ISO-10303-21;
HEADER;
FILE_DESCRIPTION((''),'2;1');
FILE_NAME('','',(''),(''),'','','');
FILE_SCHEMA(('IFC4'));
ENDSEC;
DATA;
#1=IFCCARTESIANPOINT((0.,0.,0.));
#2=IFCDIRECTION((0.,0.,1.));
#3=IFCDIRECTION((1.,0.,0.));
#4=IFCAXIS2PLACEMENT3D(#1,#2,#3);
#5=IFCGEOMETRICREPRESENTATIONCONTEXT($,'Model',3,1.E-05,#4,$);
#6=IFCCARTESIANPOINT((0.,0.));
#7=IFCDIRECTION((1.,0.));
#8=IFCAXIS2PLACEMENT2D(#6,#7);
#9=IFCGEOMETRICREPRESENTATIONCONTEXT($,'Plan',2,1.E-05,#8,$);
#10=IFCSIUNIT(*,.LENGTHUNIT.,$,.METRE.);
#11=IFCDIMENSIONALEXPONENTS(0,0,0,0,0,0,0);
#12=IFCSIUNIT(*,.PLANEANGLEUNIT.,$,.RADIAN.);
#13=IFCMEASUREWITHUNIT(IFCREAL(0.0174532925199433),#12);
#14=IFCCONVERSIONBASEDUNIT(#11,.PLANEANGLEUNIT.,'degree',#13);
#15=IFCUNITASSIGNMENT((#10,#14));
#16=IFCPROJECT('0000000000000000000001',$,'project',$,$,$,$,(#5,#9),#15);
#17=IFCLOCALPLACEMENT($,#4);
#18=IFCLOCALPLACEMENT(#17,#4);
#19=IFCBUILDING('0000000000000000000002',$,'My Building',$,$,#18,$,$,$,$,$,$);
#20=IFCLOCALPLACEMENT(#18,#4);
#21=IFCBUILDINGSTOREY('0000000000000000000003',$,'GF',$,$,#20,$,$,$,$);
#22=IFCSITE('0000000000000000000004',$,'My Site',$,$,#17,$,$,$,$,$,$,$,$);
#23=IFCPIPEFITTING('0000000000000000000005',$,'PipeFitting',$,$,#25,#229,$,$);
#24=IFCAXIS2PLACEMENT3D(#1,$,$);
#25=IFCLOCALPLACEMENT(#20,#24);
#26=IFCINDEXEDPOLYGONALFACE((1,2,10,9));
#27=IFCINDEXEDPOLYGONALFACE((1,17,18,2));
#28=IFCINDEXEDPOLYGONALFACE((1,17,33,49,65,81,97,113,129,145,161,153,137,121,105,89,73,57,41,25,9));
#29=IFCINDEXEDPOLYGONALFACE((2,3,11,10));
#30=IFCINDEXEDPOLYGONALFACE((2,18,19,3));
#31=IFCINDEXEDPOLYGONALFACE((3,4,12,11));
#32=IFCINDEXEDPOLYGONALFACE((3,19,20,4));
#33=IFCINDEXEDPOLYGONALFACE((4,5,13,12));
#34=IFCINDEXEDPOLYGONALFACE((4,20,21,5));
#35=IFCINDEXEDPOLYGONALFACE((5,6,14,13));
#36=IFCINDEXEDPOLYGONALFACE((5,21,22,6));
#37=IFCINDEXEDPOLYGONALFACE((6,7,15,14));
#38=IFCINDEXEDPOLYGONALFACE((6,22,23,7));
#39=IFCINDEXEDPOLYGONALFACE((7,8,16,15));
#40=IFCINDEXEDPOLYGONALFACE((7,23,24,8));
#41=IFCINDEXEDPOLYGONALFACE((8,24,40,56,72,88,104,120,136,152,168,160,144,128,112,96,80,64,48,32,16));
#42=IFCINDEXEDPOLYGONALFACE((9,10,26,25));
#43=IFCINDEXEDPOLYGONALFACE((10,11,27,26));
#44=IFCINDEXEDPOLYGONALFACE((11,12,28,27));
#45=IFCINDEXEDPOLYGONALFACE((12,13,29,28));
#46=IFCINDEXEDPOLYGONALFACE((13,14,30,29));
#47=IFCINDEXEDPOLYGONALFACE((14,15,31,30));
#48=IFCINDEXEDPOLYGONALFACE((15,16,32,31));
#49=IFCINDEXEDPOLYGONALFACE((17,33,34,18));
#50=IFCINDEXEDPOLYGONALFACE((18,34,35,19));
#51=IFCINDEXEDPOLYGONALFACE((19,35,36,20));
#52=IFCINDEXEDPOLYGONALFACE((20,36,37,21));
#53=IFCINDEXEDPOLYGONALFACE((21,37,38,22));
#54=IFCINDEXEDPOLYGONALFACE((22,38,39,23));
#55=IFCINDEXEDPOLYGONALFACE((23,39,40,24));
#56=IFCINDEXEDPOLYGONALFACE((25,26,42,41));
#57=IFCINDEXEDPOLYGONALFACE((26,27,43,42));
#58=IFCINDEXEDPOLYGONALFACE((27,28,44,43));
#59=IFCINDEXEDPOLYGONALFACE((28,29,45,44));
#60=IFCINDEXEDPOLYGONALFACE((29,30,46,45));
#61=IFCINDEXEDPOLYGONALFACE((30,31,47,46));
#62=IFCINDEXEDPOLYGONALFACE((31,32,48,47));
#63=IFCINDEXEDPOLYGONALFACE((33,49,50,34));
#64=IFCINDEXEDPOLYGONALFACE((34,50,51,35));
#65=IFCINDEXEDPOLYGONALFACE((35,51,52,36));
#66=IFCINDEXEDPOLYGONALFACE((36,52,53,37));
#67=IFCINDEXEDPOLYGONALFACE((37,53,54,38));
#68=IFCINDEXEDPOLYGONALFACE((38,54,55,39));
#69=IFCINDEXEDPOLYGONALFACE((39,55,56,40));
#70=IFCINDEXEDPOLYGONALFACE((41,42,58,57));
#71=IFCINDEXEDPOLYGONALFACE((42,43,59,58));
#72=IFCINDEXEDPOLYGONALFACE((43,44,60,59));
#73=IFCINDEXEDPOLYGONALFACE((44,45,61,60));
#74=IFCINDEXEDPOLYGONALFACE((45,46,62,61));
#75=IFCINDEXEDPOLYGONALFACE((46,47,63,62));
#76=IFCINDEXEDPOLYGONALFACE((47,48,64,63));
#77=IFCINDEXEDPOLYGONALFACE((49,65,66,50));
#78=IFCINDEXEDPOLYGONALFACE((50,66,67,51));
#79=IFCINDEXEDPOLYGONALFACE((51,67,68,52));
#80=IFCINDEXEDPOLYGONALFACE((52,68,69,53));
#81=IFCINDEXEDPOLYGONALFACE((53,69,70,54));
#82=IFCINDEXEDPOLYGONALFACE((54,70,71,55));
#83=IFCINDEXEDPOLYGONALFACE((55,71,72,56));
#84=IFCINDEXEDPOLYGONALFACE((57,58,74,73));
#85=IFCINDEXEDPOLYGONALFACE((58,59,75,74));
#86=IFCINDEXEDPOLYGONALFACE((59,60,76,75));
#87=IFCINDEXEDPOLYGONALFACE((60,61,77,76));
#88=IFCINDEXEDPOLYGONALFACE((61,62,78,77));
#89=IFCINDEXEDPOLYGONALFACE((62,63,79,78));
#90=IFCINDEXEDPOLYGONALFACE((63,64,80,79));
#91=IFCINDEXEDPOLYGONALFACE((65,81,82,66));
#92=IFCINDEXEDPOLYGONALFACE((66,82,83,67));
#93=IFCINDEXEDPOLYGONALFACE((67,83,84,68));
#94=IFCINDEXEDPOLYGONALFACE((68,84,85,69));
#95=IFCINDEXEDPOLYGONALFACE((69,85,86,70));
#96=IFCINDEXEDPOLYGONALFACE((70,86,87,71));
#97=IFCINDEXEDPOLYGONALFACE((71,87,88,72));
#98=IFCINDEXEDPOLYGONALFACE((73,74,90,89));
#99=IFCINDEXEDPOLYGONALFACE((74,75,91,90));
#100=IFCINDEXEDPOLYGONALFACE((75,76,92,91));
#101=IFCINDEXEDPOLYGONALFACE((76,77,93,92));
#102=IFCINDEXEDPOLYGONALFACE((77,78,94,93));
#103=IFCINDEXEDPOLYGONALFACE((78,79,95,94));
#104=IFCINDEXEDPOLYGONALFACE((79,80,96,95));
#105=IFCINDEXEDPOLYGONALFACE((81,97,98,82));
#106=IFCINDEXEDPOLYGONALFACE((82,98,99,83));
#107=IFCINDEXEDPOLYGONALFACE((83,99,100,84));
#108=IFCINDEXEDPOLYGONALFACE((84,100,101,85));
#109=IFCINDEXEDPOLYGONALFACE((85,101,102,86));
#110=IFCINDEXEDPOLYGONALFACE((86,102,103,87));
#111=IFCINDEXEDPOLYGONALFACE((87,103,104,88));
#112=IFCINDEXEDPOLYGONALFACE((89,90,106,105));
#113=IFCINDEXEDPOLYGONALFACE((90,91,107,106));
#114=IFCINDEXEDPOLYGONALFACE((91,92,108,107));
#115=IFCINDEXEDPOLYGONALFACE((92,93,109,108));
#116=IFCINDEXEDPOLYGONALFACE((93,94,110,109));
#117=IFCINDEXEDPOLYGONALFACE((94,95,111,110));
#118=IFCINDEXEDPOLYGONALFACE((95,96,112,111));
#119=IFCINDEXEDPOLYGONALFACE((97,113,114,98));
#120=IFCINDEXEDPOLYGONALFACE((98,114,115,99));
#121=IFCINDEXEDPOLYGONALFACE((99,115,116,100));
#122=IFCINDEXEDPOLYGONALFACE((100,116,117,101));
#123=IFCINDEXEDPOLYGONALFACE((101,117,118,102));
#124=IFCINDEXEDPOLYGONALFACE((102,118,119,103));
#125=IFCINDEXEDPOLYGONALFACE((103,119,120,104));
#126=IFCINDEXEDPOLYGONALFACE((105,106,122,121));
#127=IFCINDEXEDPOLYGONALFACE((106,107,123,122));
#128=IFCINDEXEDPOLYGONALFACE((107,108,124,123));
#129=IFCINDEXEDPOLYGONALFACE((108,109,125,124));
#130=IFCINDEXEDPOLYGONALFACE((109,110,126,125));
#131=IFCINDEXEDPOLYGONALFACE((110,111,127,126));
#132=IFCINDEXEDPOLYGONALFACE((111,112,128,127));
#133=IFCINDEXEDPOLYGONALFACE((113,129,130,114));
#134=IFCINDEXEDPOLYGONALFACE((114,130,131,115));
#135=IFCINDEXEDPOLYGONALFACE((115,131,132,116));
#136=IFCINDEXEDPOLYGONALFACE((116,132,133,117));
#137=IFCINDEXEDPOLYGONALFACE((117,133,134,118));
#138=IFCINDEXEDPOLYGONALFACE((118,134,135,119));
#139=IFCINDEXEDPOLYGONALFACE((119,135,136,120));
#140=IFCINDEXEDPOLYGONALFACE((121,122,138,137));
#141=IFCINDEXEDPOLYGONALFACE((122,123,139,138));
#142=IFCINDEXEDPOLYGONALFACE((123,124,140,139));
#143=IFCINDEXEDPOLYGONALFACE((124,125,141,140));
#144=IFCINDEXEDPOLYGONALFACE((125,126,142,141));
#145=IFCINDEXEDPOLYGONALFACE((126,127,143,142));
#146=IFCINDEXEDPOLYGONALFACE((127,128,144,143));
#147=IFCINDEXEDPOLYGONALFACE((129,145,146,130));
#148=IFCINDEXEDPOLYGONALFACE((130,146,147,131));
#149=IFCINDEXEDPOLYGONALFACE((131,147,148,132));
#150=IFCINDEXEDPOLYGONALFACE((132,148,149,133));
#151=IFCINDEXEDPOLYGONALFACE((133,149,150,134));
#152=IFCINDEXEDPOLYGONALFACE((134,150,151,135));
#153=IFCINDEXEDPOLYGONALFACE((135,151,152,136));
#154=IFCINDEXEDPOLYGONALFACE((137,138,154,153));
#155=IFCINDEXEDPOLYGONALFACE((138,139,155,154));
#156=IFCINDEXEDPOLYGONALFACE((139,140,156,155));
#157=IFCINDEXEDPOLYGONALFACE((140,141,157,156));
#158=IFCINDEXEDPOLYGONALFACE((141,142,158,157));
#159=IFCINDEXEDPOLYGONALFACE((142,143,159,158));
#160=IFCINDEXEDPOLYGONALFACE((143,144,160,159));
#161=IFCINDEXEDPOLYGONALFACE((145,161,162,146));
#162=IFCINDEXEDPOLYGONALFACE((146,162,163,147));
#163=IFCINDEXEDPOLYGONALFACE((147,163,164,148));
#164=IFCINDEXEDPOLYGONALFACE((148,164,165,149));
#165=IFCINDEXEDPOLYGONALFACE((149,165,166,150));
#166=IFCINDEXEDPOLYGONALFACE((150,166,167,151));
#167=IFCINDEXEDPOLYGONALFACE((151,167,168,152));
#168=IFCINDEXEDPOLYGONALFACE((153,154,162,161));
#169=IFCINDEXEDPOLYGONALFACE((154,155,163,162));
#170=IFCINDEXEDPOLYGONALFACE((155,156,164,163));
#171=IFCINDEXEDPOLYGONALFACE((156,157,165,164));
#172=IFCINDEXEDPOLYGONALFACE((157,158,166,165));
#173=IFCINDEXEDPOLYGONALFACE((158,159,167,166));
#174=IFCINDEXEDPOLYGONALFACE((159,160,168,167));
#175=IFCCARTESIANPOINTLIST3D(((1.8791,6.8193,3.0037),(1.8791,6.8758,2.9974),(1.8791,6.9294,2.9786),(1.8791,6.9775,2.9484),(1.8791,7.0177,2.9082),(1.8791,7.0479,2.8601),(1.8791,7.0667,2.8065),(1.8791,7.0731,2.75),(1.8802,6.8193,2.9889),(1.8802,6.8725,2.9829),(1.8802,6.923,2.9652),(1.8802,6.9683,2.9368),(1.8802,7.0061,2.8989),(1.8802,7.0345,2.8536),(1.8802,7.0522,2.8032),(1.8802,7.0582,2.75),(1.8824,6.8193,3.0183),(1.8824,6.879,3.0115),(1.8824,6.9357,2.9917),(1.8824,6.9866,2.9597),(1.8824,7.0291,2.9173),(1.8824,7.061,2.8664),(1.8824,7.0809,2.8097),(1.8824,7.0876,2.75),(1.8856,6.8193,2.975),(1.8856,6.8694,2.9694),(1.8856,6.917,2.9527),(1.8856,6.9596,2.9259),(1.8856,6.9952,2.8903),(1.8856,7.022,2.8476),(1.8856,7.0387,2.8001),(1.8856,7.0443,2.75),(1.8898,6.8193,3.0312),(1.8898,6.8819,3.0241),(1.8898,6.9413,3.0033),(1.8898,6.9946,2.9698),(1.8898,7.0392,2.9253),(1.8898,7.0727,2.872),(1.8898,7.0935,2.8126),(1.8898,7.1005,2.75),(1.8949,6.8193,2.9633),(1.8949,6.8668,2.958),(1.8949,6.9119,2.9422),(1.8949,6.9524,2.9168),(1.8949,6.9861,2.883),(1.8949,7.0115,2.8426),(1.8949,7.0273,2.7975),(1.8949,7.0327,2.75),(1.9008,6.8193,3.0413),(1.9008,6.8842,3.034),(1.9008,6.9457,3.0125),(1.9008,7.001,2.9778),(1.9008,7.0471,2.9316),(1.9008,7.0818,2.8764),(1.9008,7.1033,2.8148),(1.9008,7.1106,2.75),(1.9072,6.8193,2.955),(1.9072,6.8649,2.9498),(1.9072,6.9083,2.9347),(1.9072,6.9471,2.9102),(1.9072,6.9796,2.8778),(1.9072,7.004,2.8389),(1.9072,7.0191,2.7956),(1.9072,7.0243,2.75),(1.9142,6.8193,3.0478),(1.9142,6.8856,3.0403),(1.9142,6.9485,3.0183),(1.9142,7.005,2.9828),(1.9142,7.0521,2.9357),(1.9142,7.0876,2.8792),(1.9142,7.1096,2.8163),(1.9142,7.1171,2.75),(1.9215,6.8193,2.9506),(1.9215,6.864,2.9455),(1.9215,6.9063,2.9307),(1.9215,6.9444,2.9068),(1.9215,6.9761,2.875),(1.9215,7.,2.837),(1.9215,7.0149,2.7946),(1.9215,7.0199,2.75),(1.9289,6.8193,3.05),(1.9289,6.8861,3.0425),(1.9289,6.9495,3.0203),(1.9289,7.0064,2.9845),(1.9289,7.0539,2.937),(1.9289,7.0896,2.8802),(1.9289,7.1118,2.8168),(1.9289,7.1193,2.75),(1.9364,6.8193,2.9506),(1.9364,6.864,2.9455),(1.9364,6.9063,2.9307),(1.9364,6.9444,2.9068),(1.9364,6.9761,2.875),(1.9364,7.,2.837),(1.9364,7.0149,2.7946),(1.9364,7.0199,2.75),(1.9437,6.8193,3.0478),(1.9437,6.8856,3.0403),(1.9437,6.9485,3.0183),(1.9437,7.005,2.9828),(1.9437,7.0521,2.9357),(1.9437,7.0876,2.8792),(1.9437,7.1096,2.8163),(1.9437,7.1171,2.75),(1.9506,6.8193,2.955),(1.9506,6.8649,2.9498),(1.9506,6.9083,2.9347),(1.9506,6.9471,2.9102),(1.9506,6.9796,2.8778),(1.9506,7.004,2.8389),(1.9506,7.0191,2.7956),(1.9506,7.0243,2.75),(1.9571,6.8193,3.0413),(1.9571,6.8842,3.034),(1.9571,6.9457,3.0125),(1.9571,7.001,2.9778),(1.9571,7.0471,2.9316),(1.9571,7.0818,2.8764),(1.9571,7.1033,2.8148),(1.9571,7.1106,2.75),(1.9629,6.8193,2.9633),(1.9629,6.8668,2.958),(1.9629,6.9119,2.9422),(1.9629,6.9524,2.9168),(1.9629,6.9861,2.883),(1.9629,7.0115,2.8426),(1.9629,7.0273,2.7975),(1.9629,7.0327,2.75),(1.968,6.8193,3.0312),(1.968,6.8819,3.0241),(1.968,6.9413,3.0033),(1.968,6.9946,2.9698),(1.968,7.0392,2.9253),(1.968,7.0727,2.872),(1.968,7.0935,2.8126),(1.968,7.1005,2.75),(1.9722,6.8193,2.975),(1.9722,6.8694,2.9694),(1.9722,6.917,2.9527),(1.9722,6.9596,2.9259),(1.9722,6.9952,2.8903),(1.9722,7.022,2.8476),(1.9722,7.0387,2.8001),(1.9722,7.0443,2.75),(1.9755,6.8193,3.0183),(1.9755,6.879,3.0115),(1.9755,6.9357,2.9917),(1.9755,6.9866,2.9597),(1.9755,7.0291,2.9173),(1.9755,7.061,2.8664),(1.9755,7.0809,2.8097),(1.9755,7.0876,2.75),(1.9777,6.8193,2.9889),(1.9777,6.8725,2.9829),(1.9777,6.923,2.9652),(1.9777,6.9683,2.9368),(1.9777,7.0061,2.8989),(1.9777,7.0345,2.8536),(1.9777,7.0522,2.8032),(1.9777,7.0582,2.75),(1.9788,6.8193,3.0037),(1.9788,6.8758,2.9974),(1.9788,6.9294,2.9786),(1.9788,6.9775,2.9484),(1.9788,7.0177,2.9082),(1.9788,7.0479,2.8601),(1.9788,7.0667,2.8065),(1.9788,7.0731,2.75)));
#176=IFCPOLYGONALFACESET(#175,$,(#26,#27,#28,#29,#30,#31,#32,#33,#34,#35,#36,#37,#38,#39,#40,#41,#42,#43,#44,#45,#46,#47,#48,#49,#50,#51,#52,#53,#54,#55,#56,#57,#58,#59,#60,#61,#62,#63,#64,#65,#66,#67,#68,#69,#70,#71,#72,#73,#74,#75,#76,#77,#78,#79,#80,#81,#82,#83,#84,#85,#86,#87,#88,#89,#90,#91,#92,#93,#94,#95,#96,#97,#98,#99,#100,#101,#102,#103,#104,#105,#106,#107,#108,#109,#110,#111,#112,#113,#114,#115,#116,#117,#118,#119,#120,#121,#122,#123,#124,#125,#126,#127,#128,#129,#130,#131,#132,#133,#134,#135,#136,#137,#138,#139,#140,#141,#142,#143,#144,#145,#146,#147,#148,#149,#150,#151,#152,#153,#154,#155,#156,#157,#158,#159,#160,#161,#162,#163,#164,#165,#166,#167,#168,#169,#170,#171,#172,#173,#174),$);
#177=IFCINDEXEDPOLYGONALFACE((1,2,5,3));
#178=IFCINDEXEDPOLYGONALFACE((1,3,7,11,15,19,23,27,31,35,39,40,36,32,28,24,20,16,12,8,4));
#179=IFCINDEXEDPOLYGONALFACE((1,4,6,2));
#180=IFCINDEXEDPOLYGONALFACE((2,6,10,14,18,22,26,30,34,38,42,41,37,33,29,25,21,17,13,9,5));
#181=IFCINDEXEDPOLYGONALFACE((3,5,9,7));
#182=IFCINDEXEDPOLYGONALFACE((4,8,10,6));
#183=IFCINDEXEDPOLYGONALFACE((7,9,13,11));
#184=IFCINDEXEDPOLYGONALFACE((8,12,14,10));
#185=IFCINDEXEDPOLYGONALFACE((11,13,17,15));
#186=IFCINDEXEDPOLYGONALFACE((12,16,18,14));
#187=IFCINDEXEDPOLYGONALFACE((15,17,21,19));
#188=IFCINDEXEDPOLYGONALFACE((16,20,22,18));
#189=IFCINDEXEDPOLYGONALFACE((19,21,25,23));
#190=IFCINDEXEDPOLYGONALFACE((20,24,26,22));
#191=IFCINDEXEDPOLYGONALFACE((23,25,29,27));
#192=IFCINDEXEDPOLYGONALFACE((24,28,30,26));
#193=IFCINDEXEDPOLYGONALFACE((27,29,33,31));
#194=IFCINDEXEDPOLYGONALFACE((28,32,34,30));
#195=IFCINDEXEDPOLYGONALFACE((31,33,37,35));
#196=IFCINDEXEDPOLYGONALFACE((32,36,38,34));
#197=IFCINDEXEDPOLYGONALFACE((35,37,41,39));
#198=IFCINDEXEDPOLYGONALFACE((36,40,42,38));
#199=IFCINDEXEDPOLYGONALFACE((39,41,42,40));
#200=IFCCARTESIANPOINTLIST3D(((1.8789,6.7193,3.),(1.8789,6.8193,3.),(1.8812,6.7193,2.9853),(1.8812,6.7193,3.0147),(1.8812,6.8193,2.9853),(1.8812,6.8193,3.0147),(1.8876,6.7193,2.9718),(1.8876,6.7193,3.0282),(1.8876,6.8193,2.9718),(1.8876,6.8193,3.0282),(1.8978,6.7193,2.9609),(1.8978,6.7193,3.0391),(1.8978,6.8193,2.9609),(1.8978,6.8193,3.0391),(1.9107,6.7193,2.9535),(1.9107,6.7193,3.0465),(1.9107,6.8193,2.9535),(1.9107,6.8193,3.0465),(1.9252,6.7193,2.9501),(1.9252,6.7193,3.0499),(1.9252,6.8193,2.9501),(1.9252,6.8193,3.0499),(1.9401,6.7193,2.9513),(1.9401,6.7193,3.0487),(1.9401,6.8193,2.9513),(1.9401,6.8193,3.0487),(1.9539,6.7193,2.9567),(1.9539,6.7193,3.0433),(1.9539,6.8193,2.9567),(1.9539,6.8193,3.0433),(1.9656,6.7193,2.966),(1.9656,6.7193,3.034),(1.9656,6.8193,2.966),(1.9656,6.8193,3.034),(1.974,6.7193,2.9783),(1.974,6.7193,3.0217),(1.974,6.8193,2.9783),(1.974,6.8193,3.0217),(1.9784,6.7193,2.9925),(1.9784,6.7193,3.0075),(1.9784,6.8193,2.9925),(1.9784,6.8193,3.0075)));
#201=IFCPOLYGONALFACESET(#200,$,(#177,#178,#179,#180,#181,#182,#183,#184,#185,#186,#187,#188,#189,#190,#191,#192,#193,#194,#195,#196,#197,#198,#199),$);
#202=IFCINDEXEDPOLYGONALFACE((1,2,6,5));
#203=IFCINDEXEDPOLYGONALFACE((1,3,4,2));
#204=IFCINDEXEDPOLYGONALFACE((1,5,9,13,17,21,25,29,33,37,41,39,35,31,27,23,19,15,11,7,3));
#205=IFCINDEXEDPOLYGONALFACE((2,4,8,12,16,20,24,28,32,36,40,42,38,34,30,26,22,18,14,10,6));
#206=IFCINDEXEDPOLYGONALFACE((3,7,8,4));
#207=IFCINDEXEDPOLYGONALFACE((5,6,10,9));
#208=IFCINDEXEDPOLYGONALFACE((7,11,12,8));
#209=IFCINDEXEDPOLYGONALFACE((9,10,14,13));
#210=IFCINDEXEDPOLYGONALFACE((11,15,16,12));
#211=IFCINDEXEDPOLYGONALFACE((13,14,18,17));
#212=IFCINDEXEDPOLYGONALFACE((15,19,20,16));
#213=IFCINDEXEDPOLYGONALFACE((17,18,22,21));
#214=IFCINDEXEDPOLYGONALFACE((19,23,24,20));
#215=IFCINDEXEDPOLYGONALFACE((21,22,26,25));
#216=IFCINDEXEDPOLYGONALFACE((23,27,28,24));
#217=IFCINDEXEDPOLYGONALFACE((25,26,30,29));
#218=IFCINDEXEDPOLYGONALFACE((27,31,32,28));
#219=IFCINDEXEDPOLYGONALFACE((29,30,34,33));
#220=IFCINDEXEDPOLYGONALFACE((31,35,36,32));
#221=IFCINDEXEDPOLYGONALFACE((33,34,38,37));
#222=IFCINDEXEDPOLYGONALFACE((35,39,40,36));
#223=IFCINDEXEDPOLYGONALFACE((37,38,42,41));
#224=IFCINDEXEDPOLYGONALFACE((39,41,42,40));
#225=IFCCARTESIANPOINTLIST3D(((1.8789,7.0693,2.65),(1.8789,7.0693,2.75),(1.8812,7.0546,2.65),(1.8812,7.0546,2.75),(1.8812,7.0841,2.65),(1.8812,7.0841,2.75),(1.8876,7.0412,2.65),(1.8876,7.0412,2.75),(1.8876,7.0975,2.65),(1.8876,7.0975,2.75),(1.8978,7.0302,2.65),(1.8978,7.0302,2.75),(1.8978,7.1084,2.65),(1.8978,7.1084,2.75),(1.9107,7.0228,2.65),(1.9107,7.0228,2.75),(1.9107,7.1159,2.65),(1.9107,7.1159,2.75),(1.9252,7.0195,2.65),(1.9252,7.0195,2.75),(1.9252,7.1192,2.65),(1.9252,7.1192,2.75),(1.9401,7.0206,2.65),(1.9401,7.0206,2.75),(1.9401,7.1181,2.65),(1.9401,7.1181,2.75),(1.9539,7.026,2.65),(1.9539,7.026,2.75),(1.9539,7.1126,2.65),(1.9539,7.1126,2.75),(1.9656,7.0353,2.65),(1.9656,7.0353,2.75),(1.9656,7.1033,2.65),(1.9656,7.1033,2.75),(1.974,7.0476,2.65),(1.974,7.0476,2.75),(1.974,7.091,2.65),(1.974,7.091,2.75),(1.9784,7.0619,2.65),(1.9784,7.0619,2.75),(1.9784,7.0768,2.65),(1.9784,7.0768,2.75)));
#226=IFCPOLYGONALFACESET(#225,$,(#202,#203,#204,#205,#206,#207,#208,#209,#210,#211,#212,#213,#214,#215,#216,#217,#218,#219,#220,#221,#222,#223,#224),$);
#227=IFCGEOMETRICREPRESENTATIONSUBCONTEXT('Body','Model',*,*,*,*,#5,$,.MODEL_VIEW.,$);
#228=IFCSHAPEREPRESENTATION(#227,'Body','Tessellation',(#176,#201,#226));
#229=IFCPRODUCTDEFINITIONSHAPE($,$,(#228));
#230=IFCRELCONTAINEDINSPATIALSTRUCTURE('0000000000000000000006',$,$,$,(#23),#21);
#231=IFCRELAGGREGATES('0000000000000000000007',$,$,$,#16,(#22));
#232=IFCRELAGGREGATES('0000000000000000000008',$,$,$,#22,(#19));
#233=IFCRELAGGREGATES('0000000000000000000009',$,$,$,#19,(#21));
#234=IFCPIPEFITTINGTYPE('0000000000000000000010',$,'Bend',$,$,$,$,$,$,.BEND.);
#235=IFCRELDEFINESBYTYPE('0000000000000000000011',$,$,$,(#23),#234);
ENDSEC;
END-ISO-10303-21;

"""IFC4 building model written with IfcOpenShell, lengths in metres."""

from ifc_helpers import new_model, entity, si_unit, converted_unit, frame, origin_with_axes, origin_2d_with_axis, place, context, subcontext, project, spatial, circle, extrude, source, transform, mapped, type_object, type_shapes, element, save


model = new_model("IFC4")

# Units and contexts
model_context = context("Model", 3, precision=1e-05, world=origin_with_axes())
plan_context = context("Plan", 2, precision=1e-05, world=origin_2d_with_axis())
body_context_1 = subcontext(model_context, "Body", "Model", "MODEL_VIEW")
ifc_project = project(units=[si_unit("LENGTHUNIT", "METRE"), converted_unit("PLANEANGLEUNIT", "degree", entity("IfcReal", 0.0174532925199433), si_unit("PLANEANGLEUNIT", "RADIAN"), dimensions=[0, 0, 0, 0, 0, 0, 0])], contexts=[model_context, plan_context])

# Site, building, storey
site_placement = place(None, origin_with_axes())
site = spatial("IfcSite", under=ifc_project, at=site_placement, Name="My Site")
building_placement = place(site_placement, origin_with_axes())
building = spatial("IfcBuilding", under=site, at=building_placement, Name="My Building")
storey_placement = place(building_placement, origin_with_axes())
storey = spatial("IfcBuildingStorey", under=building, at=storey_placement, Name="GF")

# Pipe fitting
pipe_fitting_type = type_object("IfcPipeFittingType", Name="Bend", PredefinedType="BEND")
shared_shape_1 = source(origin_with_axes(), body_context_1, "Body", "SolidModel", [
    entity("IfcSweptDiskSolid", entity("IfcIndexedPolyCurve", entity("IfcCartesianPointList3D", [[0.0, 0.0, 0.1], [0.0, -0.0732, 0.2768], [0.0, -0.25, 0.35]]), [entity("IfcArcIndex", [1, 2, 3])]), 0.05),
    extrude(circle(Radius=0.05), origin_with_axes(), (0.0, 0.0, 1.0), 0.1),
    extrude(circle(Radius=0.05), frame((0.0, -0.25, 0.35), z_axis=(0.0, -1.0, 0.0), x_axis=(1.0, 0.0, 0.0)), (0.0, 0.0, 1.0), 0.1),
])
type_shapes(pipe_fitting_type, [shared_shape_1])
for number, where, z_axis, x_axis, name in (
    (1, (1.9289, 6.7193, 3.0), (0.0, 1.0, 0.0), (-1.0, 0.0, 0.0), "PipeFitting"),
):
    element("IfcPipeFitting", number, at=place(storey_placement, frame(where, z_axis=z_axis, x_axis=x_axis)), inside=storey, type_object=pipe_fitting_type, Name=name, context=body_context_1, shape_type="MappedRepresentation", body=[
        mapped(shared_shape_1, transform((0.0, 0.0, 0.0), x_axis=(1.0, 0.0, 0.0), y_axis=(0.0, 1.0, 0.0), z_axis=(0.0, 0.0, 1.0), scale=1.0)),
    ])

save(model, "model.ifc")
